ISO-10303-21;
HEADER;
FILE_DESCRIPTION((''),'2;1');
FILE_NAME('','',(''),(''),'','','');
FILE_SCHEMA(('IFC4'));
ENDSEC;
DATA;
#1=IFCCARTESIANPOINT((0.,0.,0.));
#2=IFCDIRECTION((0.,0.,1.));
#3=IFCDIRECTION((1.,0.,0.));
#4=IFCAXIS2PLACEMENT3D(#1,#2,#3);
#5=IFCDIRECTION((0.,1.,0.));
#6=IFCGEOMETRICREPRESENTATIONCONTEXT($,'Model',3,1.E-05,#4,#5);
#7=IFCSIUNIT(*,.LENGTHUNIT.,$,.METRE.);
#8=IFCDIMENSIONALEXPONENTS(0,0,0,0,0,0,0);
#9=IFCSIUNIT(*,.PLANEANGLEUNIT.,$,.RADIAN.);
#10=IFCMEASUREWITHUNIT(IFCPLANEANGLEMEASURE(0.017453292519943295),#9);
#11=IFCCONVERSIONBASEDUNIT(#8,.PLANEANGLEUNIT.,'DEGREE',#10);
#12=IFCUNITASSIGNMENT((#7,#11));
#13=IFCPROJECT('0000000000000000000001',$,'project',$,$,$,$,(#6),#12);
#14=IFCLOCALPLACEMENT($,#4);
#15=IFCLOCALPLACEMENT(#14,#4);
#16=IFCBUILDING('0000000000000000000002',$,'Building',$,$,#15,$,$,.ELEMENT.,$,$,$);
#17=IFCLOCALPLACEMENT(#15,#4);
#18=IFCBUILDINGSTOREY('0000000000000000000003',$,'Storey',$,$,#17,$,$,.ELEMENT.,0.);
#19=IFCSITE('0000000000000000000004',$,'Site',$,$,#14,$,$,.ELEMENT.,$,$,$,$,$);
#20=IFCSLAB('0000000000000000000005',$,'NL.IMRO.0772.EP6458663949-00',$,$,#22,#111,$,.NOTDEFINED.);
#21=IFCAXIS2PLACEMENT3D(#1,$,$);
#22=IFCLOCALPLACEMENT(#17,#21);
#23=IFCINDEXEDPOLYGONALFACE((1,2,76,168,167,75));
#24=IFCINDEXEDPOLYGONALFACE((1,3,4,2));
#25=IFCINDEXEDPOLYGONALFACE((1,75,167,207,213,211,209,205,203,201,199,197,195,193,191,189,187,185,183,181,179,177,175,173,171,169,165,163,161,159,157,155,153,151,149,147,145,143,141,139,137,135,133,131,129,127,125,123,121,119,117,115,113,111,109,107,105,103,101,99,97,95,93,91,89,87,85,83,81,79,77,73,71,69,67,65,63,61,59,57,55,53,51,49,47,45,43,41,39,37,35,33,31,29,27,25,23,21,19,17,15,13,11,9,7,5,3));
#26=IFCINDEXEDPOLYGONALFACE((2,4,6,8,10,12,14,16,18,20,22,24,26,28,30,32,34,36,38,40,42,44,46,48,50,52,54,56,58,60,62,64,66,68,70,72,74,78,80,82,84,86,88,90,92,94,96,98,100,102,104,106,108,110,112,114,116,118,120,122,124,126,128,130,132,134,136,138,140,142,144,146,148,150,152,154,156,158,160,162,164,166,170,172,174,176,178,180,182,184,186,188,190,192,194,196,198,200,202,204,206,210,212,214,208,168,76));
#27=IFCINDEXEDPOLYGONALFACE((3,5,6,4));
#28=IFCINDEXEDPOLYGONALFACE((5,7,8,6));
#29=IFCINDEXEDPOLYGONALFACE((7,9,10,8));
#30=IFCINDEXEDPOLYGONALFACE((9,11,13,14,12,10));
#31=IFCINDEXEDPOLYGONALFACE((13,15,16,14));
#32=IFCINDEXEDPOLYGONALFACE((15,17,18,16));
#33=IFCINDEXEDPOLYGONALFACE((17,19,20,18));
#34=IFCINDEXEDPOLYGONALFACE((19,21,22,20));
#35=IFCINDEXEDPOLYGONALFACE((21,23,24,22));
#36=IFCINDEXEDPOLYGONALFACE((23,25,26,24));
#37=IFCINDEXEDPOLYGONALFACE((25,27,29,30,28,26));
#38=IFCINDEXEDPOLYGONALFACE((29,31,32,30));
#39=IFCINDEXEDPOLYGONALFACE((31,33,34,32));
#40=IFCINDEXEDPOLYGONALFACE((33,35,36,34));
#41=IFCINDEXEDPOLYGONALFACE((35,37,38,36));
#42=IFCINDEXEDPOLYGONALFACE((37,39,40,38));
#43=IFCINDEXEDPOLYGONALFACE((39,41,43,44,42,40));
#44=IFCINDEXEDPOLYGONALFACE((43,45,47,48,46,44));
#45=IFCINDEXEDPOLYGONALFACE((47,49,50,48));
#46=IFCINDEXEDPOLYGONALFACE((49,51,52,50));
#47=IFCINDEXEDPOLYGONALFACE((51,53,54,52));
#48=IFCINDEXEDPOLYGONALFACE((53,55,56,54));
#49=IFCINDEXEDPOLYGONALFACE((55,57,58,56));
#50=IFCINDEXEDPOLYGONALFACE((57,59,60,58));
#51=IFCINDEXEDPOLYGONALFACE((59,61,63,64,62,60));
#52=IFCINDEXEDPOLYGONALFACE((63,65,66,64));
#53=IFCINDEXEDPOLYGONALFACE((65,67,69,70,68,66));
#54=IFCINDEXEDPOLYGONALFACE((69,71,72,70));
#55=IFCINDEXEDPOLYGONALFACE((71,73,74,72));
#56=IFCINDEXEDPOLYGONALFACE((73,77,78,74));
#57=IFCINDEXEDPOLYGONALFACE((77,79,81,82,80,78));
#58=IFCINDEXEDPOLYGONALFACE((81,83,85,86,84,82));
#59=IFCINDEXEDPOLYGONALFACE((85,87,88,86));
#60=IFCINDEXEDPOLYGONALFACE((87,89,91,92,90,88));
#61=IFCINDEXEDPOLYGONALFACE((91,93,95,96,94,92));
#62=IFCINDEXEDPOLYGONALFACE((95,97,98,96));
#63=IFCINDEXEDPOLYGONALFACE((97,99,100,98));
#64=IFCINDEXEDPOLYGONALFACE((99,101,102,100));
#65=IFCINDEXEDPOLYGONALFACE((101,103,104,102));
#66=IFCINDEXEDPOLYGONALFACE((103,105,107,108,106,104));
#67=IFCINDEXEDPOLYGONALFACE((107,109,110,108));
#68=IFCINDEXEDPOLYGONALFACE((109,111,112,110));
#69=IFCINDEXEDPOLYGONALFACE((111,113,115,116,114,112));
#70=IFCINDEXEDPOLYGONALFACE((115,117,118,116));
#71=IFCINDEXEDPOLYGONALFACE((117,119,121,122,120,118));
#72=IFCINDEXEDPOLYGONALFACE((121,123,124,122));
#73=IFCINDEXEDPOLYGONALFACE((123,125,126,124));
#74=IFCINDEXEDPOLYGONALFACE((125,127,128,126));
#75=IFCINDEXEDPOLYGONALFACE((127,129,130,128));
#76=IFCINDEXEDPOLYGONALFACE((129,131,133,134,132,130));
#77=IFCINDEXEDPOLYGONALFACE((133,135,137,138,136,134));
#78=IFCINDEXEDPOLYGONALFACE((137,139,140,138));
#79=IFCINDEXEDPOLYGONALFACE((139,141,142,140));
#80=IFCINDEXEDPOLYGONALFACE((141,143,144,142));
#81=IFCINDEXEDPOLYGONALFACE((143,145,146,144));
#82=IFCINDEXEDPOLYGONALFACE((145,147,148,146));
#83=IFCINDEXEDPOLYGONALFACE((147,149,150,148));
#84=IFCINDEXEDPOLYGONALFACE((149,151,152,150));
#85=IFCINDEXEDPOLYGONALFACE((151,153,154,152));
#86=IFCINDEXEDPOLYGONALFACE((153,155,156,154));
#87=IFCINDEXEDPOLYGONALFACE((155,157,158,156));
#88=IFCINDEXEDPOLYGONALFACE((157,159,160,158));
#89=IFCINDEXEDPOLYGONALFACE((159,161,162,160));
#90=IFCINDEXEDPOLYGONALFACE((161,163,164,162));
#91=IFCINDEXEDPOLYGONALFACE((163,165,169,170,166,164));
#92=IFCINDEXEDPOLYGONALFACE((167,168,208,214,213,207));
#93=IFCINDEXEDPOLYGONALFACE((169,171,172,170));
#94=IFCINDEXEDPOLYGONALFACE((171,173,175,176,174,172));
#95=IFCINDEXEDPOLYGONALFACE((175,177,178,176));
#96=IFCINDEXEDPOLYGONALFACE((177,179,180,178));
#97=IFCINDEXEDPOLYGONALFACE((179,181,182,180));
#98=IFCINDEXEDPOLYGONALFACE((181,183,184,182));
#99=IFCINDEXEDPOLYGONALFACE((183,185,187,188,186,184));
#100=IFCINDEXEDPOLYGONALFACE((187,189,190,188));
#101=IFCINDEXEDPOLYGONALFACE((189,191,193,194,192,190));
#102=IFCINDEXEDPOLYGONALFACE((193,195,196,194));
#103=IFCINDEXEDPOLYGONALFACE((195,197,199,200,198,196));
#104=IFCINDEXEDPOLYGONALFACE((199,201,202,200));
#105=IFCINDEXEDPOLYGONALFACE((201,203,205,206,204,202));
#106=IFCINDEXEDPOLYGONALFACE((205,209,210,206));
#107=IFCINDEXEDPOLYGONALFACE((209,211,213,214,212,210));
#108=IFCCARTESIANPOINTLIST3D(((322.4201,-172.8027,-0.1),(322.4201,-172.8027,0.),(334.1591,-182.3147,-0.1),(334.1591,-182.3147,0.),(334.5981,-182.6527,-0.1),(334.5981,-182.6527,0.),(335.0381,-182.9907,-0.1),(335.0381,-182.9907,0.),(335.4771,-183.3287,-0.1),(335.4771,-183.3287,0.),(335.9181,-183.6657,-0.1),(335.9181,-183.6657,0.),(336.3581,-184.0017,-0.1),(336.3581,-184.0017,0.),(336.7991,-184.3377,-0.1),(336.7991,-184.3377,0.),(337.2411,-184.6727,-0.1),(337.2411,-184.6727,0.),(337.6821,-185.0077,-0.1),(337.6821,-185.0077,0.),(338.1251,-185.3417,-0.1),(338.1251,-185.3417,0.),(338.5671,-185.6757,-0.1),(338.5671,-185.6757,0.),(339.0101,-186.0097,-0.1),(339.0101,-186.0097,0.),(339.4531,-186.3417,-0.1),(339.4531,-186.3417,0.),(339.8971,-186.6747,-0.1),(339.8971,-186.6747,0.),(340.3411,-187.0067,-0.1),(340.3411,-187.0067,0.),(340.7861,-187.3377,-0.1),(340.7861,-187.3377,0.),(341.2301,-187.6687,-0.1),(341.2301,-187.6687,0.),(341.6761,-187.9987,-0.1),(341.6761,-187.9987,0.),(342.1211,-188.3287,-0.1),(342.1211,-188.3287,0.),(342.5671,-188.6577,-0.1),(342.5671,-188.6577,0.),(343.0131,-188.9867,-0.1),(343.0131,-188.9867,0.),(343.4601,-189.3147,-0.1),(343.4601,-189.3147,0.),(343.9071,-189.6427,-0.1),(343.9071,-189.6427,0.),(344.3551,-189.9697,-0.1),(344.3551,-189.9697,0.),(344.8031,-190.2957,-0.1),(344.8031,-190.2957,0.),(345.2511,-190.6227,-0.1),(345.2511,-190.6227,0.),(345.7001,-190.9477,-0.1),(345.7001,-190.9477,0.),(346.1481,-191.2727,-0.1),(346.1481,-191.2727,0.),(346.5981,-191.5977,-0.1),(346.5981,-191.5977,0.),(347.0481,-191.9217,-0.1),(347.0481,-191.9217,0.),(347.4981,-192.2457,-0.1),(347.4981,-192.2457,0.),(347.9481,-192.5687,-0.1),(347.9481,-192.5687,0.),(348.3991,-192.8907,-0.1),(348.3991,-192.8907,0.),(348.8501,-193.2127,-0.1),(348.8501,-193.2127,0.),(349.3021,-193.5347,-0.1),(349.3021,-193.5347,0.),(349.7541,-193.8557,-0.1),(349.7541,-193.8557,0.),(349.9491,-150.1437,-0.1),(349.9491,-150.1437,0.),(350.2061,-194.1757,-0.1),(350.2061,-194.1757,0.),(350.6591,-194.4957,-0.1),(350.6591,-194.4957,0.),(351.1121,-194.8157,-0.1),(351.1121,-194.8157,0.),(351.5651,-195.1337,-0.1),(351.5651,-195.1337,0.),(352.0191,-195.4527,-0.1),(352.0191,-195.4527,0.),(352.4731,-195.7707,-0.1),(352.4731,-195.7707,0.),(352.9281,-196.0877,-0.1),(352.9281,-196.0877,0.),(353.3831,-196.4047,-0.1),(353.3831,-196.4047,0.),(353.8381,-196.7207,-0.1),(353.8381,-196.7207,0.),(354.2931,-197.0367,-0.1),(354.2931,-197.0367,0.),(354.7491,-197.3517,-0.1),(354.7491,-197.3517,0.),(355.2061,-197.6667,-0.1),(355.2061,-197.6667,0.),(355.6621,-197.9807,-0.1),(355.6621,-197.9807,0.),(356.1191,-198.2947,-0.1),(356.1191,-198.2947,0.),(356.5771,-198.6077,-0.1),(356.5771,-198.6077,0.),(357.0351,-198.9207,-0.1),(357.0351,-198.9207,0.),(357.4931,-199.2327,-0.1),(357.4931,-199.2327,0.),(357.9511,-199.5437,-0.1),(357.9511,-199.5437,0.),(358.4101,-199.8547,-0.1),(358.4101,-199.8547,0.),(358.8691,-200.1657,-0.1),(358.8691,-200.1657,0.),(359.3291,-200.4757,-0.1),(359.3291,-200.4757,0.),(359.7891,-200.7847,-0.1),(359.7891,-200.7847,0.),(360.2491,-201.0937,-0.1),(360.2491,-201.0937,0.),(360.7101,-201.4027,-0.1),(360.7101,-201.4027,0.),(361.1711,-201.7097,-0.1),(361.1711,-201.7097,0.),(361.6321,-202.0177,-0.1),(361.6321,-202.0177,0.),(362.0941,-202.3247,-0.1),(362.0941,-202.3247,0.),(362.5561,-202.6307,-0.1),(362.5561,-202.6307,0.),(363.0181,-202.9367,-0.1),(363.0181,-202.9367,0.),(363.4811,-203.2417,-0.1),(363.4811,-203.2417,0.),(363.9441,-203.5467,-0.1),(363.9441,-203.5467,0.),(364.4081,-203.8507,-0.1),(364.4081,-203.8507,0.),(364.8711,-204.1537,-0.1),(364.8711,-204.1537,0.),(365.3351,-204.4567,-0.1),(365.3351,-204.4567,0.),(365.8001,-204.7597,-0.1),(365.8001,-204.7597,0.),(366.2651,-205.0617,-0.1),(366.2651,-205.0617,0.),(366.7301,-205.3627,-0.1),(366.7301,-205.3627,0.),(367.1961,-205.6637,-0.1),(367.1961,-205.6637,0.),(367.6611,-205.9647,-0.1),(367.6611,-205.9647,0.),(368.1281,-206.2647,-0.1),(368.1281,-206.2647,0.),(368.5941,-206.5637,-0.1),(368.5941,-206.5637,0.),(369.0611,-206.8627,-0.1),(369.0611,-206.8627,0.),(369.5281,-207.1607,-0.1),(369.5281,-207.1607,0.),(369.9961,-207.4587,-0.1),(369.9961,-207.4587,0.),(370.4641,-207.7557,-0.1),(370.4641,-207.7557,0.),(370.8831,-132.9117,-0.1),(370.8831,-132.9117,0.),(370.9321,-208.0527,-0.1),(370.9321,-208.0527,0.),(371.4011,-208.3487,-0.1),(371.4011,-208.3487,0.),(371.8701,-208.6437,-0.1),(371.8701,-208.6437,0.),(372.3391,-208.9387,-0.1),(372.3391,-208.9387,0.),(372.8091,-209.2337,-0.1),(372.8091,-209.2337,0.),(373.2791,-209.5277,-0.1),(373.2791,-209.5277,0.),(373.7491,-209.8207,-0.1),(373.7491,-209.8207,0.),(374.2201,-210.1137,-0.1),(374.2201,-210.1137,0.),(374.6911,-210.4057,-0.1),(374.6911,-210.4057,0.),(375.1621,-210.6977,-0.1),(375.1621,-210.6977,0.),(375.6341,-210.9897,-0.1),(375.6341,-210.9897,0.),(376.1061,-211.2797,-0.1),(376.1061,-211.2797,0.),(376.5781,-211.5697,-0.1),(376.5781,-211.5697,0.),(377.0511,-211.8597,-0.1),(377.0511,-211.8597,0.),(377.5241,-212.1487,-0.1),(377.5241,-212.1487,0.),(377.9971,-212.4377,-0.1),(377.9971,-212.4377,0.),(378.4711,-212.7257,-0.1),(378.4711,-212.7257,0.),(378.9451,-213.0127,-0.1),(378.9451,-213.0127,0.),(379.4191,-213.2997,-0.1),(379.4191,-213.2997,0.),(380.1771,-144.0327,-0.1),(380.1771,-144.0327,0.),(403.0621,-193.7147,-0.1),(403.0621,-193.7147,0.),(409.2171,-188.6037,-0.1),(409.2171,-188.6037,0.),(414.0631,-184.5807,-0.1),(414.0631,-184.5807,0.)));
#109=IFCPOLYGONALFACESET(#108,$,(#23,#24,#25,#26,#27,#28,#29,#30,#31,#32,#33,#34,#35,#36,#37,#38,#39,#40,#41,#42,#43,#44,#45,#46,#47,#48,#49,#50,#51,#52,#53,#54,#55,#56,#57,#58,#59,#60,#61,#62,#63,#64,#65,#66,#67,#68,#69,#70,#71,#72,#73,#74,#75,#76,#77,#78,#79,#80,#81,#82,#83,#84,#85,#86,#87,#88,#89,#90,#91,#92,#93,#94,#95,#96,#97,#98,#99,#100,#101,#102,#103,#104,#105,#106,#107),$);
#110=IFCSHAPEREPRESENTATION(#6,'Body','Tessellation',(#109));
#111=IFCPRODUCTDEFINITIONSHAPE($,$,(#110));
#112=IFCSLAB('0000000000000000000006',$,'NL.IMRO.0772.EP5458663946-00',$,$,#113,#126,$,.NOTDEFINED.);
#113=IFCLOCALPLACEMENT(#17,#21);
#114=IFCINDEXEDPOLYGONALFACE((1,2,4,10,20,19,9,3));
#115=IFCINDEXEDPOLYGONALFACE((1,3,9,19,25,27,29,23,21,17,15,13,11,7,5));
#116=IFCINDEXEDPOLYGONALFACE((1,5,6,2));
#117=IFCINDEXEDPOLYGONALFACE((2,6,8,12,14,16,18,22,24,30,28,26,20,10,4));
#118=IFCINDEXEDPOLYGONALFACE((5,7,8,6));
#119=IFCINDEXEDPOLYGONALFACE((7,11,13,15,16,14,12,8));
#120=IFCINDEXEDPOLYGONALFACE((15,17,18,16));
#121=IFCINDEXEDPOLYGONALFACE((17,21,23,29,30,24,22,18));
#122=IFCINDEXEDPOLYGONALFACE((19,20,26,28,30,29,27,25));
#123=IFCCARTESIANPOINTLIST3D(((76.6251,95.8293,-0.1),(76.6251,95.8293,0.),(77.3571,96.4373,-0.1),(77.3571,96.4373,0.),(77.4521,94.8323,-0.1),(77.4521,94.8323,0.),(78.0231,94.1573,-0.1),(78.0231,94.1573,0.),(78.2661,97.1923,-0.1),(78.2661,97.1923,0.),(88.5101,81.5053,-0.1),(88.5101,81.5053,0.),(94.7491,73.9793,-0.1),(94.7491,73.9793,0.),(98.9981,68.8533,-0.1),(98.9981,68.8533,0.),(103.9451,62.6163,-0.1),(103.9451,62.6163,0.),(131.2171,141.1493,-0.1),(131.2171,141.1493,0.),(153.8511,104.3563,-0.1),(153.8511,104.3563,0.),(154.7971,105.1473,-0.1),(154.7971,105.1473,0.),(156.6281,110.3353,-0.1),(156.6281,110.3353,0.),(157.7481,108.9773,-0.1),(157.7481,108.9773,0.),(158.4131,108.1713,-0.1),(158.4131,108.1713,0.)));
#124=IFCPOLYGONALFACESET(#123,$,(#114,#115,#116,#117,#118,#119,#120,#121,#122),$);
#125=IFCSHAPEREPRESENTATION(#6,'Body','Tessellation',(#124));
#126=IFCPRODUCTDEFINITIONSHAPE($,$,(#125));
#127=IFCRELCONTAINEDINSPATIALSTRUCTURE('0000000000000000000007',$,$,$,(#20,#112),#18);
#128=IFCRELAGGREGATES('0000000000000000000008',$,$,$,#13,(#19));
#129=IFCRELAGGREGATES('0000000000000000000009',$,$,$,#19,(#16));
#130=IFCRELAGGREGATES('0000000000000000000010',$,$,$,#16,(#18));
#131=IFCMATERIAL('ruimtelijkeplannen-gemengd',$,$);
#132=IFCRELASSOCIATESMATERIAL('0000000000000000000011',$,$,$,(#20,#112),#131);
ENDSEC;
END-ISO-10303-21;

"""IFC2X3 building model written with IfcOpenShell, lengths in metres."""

from ifc_helpers import new_model, entity, si_unit, converted_unit, direction, frame, origin_with_axes, place, context, project, spatial, polyline, outline, extrude, material, element, save


model = new_model("IFC2X3")

# Units and contexts
model_context = context("Model", 3, precision=1e-05, world=origin_with_axes(), true_north=direction((0.0, 1.0, 0.0)))
ifc_project = project(units=[si_unit("LENGTHUNIT", "METRE"), converted_unit("PLANEANGLEUNIT", "DEGREE", entity("IfcPlaneAngleMeasure", 0.017453292519943295), si_unit("PLANEANGLEUNIT", "RADIAN"), dimensions=[0, 0, 0, 0, 0, 0, 0])], contexts=[model_context])

# Site, building, storey
site_placement = place(None, origin_with_axes())
site = spatial("IfcSite", under=ifc_project, at=site_placement, Name="Site", CompositionType="ELEMENT")
building_placement = place(site_placement, origin_with_axes())
building = spatial("IfcBuilding", under=site, at=building_placement, Name="Building", CompositionType="ELEMENT")
storey_placement = place(building_placement, origin_with_axes())
storey = spatial("IfcBuildingStorey", under=building, at=storey_placement, Name="Storey", CompositionType="ELEMENT", Elevation=0.0)

# Slabs
ifc_material_1 = material(Name="ruimtelijkeplannen-gemengd")
slab_1_placement = place(storey_placement, frame((0.0, 0.0, -0.1), z_axis=(0.0, 0.0, 1.0), x_axis=(1.0, 0.0, 0.0)))
element("IfcSlab", 1, at=slab_1_placement, inside=storey, material=ifc_material_1, Name="NL.IMRO.0772.EP6458663949-00", PredefinedType="NOTDEFINED", context=model_context, shape_type="SweptSolid", body=[
    extrude(outline(polyline([(322.4201, -172.8027), (349.9491, -150.1437), (370.8831, -132.9117), (380.1771, -144.0327), (414.0631, -184.5807), (409.2171, -188.6037), (403.0621, -193.7147), (379.4191, -213.2997), (378.9451, -213.0127), (378.4711, -212.7257), (377.9971, -212.4377), (377.5241, -212.1487), (377.0511, -211.8597), (376.5781, -211.5697), (376.1061, -211.2797), (375.6341, -210.9897), (375.1621, -210.6977), (374.6911, -210.4057), (374.2201, -210.1137), (373.7491, -209.8207), (373.2791, -209.5277), (372.8091, -209.2337), (372.3391, -208.9387), (371.8701, -208.6437), (371.4011, -208.3487), (370.9321, -208.0527), (370.4641, -207.7557), (369.9961, -207.4587), (369.5281, -207.1607), (369.0611, -206.8627), (368.5941, -206.5637), (368.1281, -206.2647), (367.6611, -205.9647), (367.1961, -205.6637), (366.7301, -205.3627), (366.2651, -205.0617), (365.8001, -204.7597), (365.3351, -204.4567), (364.8711, -204.1537), (364.4081, -203.8507), (363.9441, -203.5467), (363.4811, -203.2417), (363.0181, -202.9367), (362.5561, -202.6307), (362.0941, -202.3247), (361.6321, -202.0177), (361.1711, -201.7097), (360.7101, -201.4027), (360.2491, -201.0937), (359.7891, -200.7847), (359.3291, -200.4757), (358.8691, -200.1657), (358.4101, -199.8547), (357.9511, -199.5437), (357.4931, -199.2327), (357.0351, -198.9207), (356.5771, -198.6077), (356.1191, -198.2947), (355.6621, -197.9807), (355.2061, -197.6667), (354.7491, -197.3517), (354.2931, -197.0367), (353.8381, -196.7207), (353.3831, -196.4047), (352.9281, -196.0877), (352.4731, -195.7707), (352.0191, -195.4527), (351.5651, -195.1337), (351.1121, -194.8157), (350.6591, -194.4957), (350.2061, -194.1757), (349.7541, -193.8557), (349.3021, -193.5347), (348.8501, -193.2127), (348.3991, -192.8907), (347.9481, -192.5687), (347.4981, -192.2457), (347.0481, -191.9217), (346.5981, -191.5977), (346.1481, -191.2727), (345.7001, -190.9477), (345.2511, -190.6227), (344.8031, -190.2957), (344.3551, -189.9697), (343.9071, -189.6427), (343.4601, -189.3147), (343.0131, -188.9867), (342.5671, -188.6577), (342.1211, -188.3287), (341.6761, -187.9987), (341.2301, -187.6687), (340.7861, -187.3377), (340.3411, -187.0067), (339.8971, -186.6747), (339.4531, -186.3417), (339.0101, -186.0097), (338.5671, -185.6757), (338.1251, -185.3417), (337.6821, -185.0077), (337.2411, -184.6727), (336.7991, -184.3377), (336.3581, -184.0017), (335.9181, -183.6657), (335.4771, -183.3287), (335.0381, -182.9907), (334.5981, -182.6527), (334.1591, -182.3147), (322.4201, -172.8027)])), origin_with_axes(), (0.0, 0.0, 1.0), 0.1),
])
slab_2_placement = place(storey_placement, frame((0.0, 0.0, -0.1), z_axis=(0.0, 0.0, 1.0), x_axis=(1.0, 0.0, 0.0)))
element("IfcSlab", 2, at=slab_2_placement, inside=storey, material=ifc_material_1, Name="NL.IMRO.0772.EP5458663946-00", PredefinedType="NOTDEFINED", context=model_context, shape_type="SweptSolid", body=[
    extrude(outline(polyline([(78.0231, 94.1573), (77.4521, 94.8323), (76.6251, 95.8293), (77.3571, 96.4373), (78.2661, 97.1923), (131.2171, 141.1493), (156.6281, 110.3353), (157.7481, 108.9773), (158.4131, 108.1713), (154.7971, 105.1473), (153.8511, 104.3563), (103.9451, 62.6163), (98.9981, 68.8533), (94.7491, 73.9793), (88.5101, 81.5053), (78.0231, 94.1573)])), origin_with_axes(), (0.0, 0.0, 1.0), 0.1),
])

save(model, "model.ifc")
